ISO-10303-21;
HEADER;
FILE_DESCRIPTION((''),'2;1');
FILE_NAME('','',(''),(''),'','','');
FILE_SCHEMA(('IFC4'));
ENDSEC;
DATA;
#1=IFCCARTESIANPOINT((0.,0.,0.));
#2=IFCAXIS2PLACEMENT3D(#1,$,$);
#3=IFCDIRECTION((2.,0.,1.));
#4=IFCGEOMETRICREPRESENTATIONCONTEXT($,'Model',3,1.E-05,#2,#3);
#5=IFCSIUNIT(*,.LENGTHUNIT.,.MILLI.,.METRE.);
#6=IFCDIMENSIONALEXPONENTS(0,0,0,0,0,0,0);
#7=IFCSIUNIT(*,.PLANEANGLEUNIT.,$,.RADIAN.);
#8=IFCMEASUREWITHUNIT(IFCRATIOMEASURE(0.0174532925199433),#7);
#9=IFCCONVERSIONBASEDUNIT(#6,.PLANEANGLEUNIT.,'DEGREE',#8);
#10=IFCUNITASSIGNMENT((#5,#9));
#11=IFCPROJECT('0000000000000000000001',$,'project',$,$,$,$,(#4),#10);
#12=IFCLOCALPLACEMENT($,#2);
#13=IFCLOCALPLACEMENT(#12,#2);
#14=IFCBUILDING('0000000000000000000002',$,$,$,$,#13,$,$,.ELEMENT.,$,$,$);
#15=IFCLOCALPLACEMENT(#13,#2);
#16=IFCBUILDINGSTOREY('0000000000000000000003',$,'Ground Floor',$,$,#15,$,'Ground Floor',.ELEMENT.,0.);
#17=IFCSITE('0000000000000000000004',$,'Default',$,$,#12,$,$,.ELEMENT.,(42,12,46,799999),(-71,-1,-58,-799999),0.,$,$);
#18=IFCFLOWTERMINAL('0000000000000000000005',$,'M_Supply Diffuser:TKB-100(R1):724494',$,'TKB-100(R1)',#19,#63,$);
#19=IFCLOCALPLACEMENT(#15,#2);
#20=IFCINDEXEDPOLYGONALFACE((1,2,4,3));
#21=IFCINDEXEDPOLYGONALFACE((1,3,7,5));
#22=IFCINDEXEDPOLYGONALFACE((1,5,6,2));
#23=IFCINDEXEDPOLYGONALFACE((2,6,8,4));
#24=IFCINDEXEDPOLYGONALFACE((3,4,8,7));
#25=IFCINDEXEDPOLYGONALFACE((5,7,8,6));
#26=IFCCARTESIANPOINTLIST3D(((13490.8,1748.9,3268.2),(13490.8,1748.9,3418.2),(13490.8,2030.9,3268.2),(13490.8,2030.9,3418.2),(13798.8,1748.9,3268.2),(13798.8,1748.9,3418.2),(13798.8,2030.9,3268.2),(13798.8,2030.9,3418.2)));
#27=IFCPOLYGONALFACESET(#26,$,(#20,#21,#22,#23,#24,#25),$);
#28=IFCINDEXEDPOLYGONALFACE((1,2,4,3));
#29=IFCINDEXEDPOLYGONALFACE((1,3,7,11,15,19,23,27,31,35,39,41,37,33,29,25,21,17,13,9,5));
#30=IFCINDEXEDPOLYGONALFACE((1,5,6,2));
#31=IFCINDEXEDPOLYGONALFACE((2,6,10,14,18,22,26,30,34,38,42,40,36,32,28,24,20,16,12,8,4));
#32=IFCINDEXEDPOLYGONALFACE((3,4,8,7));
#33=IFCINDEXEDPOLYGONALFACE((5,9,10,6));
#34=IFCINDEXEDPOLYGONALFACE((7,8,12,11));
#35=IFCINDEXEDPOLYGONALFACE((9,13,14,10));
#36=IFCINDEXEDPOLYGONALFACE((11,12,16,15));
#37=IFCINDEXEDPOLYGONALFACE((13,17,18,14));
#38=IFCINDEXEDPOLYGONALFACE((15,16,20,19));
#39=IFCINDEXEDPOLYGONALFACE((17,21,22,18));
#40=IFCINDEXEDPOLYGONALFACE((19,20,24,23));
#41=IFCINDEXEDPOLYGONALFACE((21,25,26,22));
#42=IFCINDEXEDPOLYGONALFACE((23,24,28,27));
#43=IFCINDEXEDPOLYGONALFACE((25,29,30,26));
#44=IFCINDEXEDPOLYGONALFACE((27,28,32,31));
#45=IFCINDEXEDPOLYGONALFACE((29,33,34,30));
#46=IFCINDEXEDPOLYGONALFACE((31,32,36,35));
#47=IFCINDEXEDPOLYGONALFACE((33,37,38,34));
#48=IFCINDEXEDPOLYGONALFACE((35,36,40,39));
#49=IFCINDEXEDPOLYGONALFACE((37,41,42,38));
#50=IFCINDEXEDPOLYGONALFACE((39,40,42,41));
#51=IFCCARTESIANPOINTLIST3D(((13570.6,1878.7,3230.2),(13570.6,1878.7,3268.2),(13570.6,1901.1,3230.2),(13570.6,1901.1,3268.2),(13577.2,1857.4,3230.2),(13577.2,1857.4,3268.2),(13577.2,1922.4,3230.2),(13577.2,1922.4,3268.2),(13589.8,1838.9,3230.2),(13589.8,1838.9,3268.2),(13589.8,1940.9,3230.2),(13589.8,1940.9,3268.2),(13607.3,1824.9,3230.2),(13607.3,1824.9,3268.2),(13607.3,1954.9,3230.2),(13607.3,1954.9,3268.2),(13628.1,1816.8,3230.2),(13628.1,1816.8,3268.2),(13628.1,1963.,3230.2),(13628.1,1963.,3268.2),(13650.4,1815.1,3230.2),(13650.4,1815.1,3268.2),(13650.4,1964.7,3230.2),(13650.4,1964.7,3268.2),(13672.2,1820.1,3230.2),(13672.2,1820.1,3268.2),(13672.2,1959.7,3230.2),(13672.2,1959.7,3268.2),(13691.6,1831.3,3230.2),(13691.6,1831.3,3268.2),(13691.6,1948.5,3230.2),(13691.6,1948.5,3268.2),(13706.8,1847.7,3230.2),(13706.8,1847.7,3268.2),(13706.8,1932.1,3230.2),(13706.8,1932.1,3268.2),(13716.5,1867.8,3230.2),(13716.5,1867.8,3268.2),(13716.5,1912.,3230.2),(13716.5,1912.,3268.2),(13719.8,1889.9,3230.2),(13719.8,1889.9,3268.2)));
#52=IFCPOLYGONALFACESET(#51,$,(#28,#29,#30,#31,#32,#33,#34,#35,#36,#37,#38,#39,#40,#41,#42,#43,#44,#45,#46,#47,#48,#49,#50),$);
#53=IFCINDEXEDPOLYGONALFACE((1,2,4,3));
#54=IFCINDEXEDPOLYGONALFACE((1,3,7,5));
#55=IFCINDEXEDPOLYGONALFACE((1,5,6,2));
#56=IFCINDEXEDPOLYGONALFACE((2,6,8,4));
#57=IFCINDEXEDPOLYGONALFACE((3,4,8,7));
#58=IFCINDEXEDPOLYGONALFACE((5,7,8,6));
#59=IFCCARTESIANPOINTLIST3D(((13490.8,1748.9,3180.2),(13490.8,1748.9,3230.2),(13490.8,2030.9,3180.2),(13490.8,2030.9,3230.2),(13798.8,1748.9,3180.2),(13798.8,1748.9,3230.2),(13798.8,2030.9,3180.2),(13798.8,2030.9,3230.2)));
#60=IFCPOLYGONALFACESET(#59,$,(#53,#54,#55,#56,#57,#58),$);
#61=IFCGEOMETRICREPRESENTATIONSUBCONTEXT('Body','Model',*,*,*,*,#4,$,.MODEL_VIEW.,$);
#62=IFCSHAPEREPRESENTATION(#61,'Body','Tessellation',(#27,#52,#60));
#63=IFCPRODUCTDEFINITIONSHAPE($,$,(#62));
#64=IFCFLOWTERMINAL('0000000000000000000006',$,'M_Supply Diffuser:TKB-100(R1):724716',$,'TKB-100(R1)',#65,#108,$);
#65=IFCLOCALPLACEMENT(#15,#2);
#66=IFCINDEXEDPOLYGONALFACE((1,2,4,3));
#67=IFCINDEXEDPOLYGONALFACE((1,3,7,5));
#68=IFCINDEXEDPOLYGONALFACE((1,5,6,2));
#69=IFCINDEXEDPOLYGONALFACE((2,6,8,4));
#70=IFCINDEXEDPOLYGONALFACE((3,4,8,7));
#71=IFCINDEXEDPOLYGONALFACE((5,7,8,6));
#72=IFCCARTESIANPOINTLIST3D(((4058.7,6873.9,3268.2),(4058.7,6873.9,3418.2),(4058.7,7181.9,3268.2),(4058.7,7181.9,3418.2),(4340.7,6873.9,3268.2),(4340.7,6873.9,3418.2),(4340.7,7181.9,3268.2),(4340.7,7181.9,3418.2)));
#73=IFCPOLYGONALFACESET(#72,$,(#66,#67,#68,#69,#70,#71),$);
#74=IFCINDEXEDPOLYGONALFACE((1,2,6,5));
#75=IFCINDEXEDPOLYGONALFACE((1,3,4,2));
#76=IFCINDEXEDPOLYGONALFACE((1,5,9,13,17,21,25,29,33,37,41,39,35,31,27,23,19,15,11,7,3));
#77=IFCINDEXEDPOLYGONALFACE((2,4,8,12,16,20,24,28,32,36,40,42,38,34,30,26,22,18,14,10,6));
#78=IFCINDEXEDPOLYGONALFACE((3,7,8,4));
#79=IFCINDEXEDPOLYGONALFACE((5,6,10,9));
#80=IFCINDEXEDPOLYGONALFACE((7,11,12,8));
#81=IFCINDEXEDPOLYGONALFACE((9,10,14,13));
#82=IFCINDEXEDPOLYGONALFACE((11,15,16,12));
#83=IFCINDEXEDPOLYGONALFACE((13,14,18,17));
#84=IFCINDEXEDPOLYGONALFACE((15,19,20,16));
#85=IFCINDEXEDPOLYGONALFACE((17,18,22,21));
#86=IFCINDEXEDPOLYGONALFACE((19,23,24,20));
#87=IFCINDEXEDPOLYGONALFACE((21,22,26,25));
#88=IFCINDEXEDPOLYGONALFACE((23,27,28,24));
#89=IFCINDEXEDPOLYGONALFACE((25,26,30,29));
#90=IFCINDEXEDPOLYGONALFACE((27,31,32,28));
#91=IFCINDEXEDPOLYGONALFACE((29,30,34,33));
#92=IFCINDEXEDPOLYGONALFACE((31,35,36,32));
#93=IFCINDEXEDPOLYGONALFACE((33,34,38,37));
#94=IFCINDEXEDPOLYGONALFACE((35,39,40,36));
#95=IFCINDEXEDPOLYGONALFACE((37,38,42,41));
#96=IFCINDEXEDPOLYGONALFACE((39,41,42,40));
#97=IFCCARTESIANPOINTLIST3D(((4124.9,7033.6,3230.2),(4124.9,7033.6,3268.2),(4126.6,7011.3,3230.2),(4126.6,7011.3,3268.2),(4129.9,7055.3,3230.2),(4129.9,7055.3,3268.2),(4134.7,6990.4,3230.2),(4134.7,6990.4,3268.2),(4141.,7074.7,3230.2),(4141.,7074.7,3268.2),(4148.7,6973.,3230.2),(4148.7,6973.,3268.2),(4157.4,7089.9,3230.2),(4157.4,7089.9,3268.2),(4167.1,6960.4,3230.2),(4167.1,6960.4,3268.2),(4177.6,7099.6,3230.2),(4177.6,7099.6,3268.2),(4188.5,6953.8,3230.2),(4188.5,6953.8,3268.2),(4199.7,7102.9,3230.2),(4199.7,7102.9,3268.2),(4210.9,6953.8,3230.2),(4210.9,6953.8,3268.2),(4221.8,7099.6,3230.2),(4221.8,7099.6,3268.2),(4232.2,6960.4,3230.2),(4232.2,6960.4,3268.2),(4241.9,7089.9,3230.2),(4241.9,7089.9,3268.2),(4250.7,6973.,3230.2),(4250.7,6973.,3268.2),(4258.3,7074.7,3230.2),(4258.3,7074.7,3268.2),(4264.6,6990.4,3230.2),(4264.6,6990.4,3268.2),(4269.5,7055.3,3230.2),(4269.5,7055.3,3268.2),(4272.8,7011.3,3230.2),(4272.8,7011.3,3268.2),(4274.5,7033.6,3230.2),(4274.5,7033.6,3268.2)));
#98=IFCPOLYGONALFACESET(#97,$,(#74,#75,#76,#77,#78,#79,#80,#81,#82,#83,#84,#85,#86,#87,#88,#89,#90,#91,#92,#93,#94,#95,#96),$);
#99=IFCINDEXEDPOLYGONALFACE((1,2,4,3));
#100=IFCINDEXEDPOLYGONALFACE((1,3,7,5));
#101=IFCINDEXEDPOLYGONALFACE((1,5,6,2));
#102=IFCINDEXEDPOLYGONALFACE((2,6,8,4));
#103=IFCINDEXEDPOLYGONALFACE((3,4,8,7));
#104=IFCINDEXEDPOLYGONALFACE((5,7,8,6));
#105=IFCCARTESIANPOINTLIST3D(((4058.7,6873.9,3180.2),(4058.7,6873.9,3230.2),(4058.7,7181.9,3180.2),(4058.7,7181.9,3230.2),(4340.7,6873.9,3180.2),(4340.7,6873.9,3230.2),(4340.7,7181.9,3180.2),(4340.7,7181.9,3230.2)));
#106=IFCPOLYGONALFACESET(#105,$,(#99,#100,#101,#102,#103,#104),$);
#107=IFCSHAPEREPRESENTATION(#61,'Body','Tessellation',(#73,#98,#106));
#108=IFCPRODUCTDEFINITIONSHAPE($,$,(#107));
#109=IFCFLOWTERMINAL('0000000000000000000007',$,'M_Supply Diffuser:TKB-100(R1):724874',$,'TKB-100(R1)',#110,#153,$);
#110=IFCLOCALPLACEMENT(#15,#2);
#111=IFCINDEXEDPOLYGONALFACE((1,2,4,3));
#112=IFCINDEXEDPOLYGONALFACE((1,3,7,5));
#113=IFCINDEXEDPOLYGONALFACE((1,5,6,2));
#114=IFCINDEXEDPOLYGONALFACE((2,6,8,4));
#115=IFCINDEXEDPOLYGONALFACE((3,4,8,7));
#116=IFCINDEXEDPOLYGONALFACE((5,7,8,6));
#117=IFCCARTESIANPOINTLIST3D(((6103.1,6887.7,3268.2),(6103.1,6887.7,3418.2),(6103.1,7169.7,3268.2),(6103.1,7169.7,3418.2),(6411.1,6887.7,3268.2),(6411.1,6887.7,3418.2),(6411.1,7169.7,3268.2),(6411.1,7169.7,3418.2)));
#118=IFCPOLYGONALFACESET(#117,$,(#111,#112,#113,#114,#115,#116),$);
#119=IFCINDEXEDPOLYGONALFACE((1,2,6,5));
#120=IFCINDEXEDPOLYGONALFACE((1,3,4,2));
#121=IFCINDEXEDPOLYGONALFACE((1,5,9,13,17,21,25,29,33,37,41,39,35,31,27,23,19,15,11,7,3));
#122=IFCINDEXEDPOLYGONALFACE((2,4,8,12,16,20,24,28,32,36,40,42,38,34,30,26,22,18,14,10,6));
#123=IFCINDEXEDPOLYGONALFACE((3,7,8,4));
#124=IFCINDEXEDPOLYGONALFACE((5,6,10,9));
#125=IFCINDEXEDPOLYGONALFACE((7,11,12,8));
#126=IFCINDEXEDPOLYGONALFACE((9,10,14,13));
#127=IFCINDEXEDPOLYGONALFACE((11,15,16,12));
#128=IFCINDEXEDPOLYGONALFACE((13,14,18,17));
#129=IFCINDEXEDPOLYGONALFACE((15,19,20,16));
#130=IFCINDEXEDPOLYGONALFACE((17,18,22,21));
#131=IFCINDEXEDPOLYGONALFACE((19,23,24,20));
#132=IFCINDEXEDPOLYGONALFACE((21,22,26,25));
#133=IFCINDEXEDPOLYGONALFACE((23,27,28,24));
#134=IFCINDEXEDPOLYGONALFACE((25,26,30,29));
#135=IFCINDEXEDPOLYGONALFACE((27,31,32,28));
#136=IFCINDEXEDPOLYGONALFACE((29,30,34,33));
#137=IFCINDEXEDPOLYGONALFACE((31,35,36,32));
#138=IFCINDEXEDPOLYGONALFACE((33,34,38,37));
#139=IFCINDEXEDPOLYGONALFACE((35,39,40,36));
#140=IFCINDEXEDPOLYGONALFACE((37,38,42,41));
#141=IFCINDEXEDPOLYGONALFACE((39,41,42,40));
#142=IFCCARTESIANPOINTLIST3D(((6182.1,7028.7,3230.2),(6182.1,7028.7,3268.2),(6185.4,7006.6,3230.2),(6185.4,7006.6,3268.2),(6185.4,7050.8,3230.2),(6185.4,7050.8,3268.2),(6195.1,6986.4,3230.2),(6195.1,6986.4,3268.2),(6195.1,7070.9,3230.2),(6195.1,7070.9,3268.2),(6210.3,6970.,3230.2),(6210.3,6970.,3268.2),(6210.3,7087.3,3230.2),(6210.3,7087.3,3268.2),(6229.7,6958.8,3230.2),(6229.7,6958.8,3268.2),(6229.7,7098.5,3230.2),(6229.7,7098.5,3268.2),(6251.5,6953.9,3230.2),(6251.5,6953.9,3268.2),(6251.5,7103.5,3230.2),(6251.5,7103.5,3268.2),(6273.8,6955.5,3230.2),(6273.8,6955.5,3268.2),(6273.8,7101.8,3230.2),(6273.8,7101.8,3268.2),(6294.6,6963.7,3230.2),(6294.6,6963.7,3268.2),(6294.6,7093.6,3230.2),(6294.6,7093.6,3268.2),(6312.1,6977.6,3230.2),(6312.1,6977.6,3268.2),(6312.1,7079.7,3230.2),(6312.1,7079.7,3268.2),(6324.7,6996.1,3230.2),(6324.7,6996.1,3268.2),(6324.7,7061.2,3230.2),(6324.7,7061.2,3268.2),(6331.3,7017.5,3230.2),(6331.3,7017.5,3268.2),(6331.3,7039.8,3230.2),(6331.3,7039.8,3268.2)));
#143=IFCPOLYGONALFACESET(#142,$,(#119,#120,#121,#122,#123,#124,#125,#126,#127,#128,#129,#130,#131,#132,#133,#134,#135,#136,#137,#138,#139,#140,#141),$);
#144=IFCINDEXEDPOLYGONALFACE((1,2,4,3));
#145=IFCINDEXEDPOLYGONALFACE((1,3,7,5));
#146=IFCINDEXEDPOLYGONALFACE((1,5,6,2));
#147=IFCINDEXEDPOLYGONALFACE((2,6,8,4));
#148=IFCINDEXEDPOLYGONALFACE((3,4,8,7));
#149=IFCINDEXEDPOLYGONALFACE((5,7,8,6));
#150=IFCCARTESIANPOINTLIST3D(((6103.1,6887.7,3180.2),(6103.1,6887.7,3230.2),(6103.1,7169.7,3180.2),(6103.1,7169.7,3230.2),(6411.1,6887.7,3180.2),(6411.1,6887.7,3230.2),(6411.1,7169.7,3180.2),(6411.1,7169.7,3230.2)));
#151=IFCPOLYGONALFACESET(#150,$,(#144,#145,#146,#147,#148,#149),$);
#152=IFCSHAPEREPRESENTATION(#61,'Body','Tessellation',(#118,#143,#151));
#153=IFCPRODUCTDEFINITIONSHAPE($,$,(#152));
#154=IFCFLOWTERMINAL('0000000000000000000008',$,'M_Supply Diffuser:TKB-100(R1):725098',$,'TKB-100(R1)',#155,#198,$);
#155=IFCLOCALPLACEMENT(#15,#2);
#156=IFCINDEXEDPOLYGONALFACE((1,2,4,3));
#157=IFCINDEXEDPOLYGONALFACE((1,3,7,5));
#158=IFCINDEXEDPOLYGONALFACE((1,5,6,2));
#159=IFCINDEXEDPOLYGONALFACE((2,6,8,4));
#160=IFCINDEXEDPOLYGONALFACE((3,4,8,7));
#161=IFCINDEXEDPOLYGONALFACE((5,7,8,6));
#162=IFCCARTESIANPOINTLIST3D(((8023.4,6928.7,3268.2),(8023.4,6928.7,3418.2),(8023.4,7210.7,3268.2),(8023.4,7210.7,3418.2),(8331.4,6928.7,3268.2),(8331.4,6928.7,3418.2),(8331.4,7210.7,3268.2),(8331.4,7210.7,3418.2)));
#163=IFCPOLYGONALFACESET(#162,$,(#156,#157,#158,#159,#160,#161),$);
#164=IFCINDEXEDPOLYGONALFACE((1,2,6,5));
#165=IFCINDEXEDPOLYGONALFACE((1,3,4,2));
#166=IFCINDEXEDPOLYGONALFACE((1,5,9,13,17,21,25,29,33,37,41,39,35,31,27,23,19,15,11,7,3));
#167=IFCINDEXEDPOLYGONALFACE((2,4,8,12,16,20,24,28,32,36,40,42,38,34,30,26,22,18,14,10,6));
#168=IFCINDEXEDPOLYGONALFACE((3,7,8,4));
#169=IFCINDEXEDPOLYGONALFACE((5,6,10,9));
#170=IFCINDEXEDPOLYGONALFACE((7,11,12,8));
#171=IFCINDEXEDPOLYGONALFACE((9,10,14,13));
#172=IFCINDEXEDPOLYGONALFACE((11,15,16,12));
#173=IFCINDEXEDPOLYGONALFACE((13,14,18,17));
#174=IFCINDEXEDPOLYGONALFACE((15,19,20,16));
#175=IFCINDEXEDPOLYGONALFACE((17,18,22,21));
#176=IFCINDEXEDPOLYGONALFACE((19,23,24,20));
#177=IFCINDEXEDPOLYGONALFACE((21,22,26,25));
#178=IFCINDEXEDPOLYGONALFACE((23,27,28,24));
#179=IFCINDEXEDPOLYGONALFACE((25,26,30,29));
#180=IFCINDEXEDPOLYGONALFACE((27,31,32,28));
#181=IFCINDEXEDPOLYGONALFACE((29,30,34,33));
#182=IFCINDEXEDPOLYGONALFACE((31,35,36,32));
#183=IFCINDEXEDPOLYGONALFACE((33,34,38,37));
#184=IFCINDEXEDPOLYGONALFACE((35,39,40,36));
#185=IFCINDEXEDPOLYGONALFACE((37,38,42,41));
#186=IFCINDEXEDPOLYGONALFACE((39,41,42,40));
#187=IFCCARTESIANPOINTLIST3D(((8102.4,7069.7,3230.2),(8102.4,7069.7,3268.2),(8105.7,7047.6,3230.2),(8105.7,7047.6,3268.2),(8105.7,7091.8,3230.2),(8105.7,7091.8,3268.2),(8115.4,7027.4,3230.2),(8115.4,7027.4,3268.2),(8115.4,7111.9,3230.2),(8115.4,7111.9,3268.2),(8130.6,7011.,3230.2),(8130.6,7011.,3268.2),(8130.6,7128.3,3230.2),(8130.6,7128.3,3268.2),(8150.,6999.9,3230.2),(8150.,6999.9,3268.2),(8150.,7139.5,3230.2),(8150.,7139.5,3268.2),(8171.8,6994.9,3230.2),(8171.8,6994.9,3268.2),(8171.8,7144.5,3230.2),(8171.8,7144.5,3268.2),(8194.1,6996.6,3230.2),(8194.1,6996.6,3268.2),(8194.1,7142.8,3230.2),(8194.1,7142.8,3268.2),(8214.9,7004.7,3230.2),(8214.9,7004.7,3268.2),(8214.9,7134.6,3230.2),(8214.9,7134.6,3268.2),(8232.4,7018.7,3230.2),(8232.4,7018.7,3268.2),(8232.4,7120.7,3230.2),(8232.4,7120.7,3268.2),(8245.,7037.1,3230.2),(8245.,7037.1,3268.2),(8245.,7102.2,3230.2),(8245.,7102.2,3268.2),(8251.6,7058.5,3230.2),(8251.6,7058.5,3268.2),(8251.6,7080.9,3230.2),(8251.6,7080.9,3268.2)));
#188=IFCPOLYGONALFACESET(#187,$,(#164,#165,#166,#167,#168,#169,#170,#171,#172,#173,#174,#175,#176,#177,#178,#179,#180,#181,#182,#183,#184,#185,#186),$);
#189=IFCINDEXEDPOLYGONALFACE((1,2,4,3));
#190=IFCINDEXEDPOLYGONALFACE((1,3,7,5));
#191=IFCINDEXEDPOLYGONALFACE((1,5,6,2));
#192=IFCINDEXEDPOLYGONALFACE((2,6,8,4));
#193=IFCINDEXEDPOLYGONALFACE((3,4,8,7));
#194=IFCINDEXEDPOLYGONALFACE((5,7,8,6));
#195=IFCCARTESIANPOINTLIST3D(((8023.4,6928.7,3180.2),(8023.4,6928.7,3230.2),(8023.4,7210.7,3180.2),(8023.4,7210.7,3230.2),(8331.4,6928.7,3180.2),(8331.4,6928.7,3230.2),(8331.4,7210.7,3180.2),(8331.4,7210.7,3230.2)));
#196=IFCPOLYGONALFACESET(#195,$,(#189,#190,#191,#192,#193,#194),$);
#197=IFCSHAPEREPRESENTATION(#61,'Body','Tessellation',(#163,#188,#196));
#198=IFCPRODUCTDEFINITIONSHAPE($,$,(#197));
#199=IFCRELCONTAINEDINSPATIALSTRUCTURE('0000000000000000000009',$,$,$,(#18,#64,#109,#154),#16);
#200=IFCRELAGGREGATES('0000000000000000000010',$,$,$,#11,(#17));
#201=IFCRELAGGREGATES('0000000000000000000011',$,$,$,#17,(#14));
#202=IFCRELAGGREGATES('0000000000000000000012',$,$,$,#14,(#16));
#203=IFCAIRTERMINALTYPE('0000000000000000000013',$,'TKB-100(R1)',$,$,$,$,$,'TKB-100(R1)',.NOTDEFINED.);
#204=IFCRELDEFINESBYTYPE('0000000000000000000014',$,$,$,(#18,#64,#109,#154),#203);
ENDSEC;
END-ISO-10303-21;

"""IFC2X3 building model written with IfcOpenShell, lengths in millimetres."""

from ifc_helpers import new_model, entity, si_unit, converted_unit, direction, frame, frame_2d, origin, origin_2d_with_axis, place, context, subcontext, project, spatial, rectangle, circle, extrude, source, transform, mapped, type_object, type_shapes, element, save


model = new_model("IFC2X3")

# Units and contexts
model_context = context("Model", 3, precision=1e-05, world=origin(), true_north=direction((2.0, 0.0, 1.0)))
body_context = subcontext(model_context, "Body", "Model", "MODEL_VIEW")
ifc_project = project(units=[si_unit("LENGTHUNIT", "METRE", prefix="MILLI"), converted_unit("PLANEANGLEUNIT", "DEGREE", entity("IfcRatioMeasure", 0.0174532925199433), si_unit("PLANEANGLEUNIT", "RADIAN"), dimensions=[0, 0, 0, 0, 0, 0, 0])], contexts=[model_context])

# Site, building, storey
site_placement = place(None, origin())
site = spatial("IfcSite", under=ifc_project, at=site_placement, Name="Default", CompositionType="ELEMENT", RefLatitude=(42, 12, 46, 799999), RefLongitude=(-71, -1, -58, -799999), RefElevation=0.0)
building_placement = place(site_placement, origin())
building = spatial("IfcBuilding", under=site, at=building_placement, CompositionType="ELEMENT")
storey_placement = place(building_placement, origin())
storey = spatial("IfcBuildingStorey", under=building, at=storey_placement, Name="Ground Floor", LongName="Ground Floor", CompositionType="ELEMENT", Elevation=0.0)

# Flow terminals
air_terminal_type_1 = type_object("IfcAirTerminalType", Name="TKB-100(R1)", ElementType="TKB-100(R1)", PredefinedType="NOTDEFINED")
shared_shape_1 = source(origin(), body_context, "Body", "SweptSolid", [
    extrude(rectangle(XDim=308.0, YDim=282.0, at=origin_2d_with_axis()), frame((0.0, 0.0, 88.0), z_axis=(0.0, 0.0, 1.0), x_axis=(-1.0, 0.0, 0.0)), (0.0, 0.0, 1.0), 150.0),
    extrude(circle(Radius=75.0, at=frame_2d((0.0, 0.0), x_axis=(1.0, 0.0))), frame((0.0, 0.0, 50.0)), (0.0, 0.0, 1.0), 38.0),
    extrude(rectangle(XDim=282.0, YDim=308.0, at=origin_2d_with_axis()), frame((0.0, 0.0, 0.0), z_axis=(0.0, 0.0, 1.0), x_axis=(0.0, 1.0, 0.0)), (0.0, 0.0, 1.0), 50.0),
])
type_shapes(air_terminal_type_1, [shared_shape_1])
for number, where, name in (
    (1, (13644.8, 1889.9, 3180.2), "M_Supply Diffuser:TKB-100(R1):724494"),
):
    element("IfcFlowTerminal", number, at=place(storey_placement, frame(where)), inside=storey, type_object=air_terminal_type_1, Name=name, ObjectType="TKB-100(R1)", context=body_context, shape_type="MappedRepresentation", body=[
        mapped(shared_shape_1, transform((0.0, 0.0, 0.0), scale=1.0)),
    ])
for number, where, z_axis, x_axis, name in (
    (2, (4199.7, 7027.9, 3180.2), (0.0, 0.0, 1.0), (0.0, 1.0, 0.0), "M_Supply Diffuser:TKB-100(R1):724716"),
    (3, (6257.1, 7028.7, 3180.2), (0.0, 0.0, 1.0), (-1.0, 0.0, 0.0), "M_Supply Diffuser:TKB-100(R1):724874"),
    (4, (8177.4, 7069.7, 3180.2), (0.0, 0.0, 1.0), (-1.0, 0.0, 0.0), "M_Supply Diffuser:TKB-100(R1):725098"),
):
    element("IfcFlowTerminal", number, at=place(storey_placement, frame(where, z_axis=z_axis, x_axis=x_axis)), inside=storey, type_object=air_terminal_type_1, Name=name, ObjectType="TKB-100(R1)", context=body_context, shape_type="MappedRepresentation", body=[
        mapped(shared_shape_1, transform((0.0, 0.0, 0.0), scale=1.0)),
    ])

save(model, "model.ifc")
